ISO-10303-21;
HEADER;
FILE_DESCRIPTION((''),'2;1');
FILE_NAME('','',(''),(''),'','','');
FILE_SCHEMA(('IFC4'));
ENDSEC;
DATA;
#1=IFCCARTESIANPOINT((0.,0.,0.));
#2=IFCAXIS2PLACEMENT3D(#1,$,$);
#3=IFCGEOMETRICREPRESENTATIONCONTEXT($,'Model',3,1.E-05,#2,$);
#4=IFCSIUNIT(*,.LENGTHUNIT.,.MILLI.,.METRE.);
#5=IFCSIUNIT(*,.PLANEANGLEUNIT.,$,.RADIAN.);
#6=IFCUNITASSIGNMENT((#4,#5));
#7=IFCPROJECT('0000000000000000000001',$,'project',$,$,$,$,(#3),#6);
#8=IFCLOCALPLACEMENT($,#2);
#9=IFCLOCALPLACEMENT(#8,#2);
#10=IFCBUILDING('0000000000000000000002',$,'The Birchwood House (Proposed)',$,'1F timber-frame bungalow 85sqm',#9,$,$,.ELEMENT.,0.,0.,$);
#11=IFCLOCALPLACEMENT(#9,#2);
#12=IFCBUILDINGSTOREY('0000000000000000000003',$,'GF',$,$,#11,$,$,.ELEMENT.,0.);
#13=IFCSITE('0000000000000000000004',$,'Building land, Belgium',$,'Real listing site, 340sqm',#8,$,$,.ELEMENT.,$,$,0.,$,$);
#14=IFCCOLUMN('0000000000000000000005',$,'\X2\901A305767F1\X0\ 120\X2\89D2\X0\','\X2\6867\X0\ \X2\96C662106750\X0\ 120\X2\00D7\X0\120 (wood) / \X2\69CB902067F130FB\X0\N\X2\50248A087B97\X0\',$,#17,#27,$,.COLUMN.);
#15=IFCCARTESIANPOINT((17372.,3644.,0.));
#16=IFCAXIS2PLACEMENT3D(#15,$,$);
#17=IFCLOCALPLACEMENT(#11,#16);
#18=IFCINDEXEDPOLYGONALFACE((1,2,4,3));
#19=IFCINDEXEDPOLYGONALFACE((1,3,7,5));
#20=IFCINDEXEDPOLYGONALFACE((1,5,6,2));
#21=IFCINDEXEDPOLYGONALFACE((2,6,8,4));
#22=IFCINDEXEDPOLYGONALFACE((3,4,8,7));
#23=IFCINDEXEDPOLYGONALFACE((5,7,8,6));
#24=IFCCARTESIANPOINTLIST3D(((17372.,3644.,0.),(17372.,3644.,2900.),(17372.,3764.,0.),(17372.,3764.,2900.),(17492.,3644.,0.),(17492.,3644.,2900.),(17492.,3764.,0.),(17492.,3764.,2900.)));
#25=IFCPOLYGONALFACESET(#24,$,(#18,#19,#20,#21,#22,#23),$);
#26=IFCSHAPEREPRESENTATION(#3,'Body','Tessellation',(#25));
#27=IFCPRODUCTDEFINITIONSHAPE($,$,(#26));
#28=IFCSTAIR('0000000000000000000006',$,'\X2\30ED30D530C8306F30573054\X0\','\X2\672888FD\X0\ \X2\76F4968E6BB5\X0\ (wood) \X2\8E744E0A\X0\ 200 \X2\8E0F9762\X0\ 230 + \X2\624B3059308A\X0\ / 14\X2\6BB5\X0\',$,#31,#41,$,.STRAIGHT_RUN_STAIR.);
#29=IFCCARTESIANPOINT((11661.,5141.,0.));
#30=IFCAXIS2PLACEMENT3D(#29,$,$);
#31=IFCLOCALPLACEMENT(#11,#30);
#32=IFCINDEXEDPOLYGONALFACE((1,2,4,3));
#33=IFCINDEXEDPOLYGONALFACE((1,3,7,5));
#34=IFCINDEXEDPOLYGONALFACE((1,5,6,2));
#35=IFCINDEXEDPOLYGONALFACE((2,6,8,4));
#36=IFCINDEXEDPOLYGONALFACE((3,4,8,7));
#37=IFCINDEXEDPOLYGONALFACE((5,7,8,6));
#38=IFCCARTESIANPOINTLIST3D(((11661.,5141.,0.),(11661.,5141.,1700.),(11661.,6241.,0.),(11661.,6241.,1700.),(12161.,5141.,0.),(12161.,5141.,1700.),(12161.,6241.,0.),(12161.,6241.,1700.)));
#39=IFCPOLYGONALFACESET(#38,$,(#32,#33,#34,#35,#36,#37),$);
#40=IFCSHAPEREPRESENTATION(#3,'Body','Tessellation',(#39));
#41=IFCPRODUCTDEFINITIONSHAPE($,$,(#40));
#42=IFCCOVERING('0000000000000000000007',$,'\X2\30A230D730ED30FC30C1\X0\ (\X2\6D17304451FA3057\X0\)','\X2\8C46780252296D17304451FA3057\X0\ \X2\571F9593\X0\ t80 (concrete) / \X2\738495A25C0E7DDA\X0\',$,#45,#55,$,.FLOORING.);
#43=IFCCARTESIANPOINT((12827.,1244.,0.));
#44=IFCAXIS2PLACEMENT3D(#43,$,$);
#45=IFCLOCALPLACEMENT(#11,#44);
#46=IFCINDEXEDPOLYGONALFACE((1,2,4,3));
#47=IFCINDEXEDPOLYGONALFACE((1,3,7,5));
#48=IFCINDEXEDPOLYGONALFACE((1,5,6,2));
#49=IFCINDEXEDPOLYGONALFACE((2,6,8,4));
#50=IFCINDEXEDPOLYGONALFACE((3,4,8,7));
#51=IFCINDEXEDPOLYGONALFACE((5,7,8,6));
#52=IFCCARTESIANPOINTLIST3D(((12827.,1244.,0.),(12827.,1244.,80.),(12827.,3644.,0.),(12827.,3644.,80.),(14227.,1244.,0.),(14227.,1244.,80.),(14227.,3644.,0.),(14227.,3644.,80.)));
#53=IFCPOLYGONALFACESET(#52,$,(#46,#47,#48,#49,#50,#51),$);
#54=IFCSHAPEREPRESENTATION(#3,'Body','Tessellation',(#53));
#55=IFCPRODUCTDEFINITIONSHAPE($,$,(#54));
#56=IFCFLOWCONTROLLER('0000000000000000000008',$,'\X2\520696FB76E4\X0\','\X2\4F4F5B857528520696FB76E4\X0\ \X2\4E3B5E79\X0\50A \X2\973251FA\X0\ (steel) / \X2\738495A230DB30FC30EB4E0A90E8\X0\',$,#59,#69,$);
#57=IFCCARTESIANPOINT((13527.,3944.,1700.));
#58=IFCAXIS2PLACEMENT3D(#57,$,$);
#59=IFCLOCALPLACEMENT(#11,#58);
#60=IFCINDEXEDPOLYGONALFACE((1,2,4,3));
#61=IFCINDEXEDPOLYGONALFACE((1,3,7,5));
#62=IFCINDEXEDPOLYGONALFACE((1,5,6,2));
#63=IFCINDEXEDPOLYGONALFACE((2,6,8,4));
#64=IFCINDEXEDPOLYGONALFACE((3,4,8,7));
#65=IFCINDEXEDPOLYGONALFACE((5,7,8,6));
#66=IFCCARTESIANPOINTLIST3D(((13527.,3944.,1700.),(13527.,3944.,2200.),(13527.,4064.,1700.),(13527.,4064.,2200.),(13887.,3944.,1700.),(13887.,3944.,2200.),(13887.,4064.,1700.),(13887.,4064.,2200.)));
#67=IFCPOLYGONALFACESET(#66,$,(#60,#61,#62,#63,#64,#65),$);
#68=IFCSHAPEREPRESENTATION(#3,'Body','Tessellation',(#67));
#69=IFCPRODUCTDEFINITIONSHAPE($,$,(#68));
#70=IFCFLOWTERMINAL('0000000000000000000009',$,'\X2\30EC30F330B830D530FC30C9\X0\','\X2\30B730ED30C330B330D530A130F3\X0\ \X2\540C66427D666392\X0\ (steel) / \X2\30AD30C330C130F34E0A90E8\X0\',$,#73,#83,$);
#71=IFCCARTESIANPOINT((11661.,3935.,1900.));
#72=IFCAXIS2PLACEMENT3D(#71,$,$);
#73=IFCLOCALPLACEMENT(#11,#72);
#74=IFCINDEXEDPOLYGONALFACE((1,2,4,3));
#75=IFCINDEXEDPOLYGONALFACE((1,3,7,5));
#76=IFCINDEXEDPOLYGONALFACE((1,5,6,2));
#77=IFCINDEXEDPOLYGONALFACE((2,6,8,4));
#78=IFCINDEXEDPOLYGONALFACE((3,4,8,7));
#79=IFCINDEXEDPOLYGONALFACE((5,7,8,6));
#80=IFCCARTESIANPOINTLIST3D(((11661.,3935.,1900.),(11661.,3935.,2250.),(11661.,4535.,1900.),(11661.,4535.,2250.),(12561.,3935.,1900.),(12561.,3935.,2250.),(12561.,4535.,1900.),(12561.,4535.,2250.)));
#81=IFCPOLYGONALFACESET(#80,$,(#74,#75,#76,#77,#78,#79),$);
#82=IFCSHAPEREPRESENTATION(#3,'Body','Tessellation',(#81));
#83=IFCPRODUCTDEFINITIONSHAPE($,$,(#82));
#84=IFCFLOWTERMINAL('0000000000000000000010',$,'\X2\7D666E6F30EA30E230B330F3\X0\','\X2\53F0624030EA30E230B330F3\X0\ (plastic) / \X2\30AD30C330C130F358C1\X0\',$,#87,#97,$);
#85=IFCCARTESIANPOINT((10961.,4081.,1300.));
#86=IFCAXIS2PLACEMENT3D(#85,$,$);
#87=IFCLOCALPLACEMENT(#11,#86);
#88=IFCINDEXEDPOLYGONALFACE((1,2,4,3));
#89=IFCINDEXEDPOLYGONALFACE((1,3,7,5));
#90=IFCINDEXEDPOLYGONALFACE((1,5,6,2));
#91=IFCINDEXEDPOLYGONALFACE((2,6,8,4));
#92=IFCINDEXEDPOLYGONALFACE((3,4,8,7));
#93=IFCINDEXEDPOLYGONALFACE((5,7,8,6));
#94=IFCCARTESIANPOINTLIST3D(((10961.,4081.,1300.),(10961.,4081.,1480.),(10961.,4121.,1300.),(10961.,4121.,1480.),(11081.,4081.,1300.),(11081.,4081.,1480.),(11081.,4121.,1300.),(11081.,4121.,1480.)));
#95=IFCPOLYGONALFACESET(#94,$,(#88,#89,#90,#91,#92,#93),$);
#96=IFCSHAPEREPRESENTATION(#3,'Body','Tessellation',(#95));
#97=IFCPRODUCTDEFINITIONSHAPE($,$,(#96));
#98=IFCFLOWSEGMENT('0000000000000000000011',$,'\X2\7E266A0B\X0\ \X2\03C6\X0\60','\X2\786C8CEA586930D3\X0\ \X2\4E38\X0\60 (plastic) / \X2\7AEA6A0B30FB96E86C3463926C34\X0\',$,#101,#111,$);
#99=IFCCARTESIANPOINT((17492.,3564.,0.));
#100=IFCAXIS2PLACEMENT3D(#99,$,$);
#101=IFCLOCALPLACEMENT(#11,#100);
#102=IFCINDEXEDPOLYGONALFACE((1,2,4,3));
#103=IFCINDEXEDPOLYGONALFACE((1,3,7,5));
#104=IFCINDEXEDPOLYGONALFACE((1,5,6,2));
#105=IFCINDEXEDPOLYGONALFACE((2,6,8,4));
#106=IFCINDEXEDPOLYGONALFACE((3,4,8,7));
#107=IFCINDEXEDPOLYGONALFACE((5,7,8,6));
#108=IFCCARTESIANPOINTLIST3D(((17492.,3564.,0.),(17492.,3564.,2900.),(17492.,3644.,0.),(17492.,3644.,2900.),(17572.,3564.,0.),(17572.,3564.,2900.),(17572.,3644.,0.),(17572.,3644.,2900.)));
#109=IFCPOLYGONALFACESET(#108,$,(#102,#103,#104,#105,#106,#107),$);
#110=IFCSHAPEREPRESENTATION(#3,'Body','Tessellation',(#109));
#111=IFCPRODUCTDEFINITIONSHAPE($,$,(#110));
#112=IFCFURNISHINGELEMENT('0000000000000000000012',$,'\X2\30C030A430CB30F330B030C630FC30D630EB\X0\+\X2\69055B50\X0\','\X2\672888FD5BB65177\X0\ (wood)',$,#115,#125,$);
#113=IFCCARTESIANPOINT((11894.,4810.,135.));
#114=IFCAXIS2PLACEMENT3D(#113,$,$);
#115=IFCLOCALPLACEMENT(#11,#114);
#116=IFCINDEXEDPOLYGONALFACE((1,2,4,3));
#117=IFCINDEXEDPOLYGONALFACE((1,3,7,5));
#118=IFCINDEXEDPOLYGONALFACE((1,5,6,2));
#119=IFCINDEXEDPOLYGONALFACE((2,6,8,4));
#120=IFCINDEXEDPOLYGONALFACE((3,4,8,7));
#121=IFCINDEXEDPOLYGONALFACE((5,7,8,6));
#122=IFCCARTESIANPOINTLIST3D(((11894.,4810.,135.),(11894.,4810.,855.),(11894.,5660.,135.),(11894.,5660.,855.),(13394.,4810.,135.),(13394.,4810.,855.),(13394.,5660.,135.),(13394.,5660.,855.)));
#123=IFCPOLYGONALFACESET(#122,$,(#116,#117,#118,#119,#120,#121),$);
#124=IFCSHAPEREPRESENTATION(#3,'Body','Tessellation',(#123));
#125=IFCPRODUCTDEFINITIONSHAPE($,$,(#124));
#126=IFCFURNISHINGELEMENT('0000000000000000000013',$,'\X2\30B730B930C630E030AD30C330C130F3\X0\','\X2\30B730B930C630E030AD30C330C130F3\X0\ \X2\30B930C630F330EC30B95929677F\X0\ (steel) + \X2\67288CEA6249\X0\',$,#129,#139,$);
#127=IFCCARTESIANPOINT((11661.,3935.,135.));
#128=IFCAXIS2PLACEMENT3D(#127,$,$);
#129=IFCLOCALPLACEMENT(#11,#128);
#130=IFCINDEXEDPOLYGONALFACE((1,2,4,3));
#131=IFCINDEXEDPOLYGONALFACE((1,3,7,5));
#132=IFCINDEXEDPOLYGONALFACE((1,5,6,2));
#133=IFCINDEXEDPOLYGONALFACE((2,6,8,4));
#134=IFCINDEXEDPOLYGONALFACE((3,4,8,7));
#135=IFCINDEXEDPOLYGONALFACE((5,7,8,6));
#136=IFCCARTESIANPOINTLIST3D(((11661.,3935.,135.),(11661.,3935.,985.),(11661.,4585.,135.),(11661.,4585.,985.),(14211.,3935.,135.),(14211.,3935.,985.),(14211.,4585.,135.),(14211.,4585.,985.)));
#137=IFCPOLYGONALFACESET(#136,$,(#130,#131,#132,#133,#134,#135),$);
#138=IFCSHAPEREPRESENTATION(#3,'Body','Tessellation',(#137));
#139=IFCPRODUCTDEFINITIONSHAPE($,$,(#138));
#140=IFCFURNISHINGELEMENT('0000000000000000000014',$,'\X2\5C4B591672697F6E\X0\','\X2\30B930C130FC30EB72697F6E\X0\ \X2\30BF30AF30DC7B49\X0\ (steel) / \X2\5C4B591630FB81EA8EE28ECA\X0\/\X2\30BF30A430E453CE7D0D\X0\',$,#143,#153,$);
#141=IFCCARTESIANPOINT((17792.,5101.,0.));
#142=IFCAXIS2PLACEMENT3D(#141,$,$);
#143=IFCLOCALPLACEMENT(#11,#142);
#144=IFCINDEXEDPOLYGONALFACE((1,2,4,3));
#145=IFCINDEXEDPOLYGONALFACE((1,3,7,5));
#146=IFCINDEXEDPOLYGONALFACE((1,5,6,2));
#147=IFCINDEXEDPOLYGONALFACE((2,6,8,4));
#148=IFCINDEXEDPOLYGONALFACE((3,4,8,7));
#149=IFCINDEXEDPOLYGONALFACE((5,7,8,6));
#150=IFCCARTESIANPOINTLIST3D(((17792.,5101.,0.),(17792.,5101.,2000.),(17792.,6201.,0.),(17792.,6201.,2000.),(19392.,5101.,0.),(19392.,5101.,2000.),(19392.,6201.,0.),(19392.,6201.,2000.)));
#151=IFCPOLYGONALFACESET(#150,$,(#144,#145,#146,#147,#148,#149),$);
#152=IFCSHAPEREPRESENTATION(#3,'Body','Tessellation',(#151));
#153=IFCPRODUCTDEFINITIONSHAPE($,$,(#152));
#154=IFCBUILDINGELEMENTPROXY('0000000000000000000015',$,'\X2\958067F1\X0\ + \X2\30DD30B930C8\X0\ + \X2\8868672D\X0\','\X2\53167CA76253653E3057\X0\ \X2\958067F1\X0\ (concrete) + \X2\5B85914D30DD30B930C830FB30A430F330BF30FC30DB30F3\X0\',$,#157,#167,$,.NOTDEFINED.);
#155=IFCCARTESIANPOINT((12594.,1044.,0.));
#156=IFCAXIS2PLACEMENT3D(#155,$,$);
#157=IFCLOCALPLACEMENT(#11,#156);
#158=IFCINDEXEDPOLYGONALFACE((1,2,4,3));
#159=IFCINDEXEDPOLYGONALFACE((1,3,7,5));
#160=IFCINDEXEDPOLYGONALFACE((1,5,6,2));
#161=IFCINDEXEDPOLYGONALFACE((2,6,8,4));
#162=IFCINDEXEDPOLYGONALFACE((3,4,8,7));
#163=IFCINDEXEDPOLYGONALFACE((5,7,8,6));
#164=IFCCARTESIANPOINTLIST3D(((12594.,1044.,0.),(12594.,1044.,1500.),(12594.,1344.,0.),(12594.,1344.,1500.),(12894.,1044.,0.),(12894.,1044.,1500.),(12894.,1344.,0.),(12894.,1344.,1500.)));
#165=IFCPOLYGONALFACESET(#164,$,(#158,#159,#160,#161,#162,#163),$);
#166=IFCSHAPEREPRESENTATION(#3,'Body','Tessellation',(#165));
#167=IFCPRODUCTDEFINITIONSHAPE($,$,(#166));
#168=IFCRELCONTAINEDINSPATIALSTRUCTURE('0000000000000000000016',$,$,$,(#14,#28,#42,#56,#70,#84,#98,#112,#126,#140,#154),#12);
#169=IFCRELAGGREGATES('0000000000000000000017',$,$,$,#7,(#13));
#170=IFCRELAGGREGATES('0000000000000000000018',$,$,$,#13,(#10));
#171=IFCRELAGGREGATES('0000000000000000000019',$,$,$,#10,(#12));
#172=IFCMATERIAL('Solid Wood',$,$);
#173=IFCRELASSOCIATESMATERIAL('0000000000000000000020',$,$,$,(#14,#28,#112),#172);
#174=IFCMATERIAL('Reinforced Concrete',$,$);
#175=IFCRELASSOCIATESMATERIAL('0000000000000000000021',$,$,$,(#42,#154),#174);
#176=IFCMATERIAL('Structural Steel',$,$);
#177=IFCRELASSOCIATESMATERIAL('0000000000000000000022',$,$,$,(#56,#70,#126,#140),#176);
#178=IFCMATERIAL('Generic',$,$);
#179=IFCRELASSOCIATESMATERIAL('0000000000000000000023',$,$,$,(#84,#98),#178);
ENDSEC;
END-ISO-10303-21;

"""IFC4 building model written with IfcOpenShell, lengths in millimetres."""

from ifc_helpers import new_model, si_unit, frame, frame_2d, origin, place, context, project, spatial, rectangle, extrude, material, element, save


model = new_model("IFC4")

# Units and contexts
model_context = context("Model", 3, precision=1e-05, world=origin())
ifc_project = project(units=[si_unit("LENGTHUNIT", "METRE", prefix="MILLI"), si_unit("PLANEANGLEUNIT", "RADIAN")], contexts=[model_context])

# Site, building, storey
site_placement = place(None, origin())
site = spatial("IfcSite", under=ifc_project, at=site_placement, Name="Building land, Belgium", ObjectType="Real listing site, 340sqm", CompositionType="ELEMENT", RefElevation=0.0)
building_placement = place(site_placement, origin())
building = spatial("IfcBuilding", under=site, at=building_placement, Name="The Birchwood House (Proposed)", ObjectType="1F timber-frame bungalow 85sqm", CompositionType="ELEMENT", ElevationOfRefHeight=0.0, ElevationOfTerrain=0.0)
storey_placement = place(building_placement, origin())
storey = spatial("IfcBuildingStorey", under=building, at=storey_placement, Name="GF", CompositionType="ELEMENT", Elevation=0.0)

# Column
ifc_material_1 = material(Name="Solid Wood")
column_1_placement = place(storey_placement, frame((17372.0, 3644.0, 0.0)))
element("IfcColumn", 1, at=column_1_placement, inside=storey, material=ifc_material_1, Name="通し柱 120角", Description="桧 集成材 120×120 (wood) / 構造柱・N値計算", PredefinedType="COLUMN", context=model_context, shape_type="SweptSolid", body=[
    extrude(rectangle(XDim=120.0, YDim=120.0, at=frame_2d((60.0, 60.0))), frame((17372.0, 3644.0, 0.0)), (0.0, 0.0, 1.0), 2900.0),
])

# Stair
stair_placement = place(storey_placement, frame((11661.0, 5141.0, 0.0)))
element("IfcStair", 2, at=stair_placement, inside=storey, material=ifc_material_1, Name="ロフトはしご", Description="木製 直階段 (wood) 蹴上 200 踏面 230 + 手すり / 14段", PredefinedType="STRAIGHT_RUN_STAIR", context=model_context, shape_type="SweptSolid", body=[
    extrude(rectangle(XDim=500.0, YDim=1100.0, at=frame_2d((250.0, 550.0))), frame((11661.0, 5141.0, 0.0)), (0.0, 0.0, 1.0), 1700.0),
])

# Covering
ifc_material_2 = material(Name="Reinforced Concrete")
covering_placement = place(storey_placement, frame((12827.0, 1244.0, 0.0)))
element("IfcCovering", 3, at=covering_placement, inside=storey, material=ifc_material_2, Name="アプローチ (洗い出し)", Description="豆砂利洗い出し 土間 t80 (concrete) / 玄関導線", PredefinedType="FLOORING", context=model_context, shape_type="SweptSolid", body=[
    extrude(rectangle(XDim=1400.0, YDim=2400.0, at=frame_2d((700.0, 1200.0))), frame((12827.0, 1244.0, 0.0)), (0.0, 0.0, 1.0), 80.0),
])

# Flow controller
ifc_material_3 = material(Name="Structural Steel")
flow_controller_placement = place(storey_placement, frame((13527.0, 3944.0, 1700.0)))
element("IfcFlowController", 4, at=flow_controller_placement, inside=storey, material=ifc_material_3, Name="分電盤", Description="住宅用分電盤 主幹50A 露出 (steel) / 玄関ホール上部", context=model_context, shape_type="SweptSolid", body=[
    extrude(rectangle(XDim=360.0, YDim=120.0, at=frame_2d((180.0, 60.0))), frame((13527.0, 3944.0, 1700.0)), (0.0, 0.0, 1.0), 500.0),
])

# Flow terminals
flow_terminal_1_placement = place(storey_placement, frame((11661.0, 3935.0, 1900.0)))
element("IfcFlowTerminal", 5, at=flow_terminal_1_placement, inside=storey, material=ifc_material_3, Name="レンジフード", Description="シロッコファン 同時給排 (steel) / キッチン上部", context=model_context, shape_type="SweptSolid", body=[
    extrude(rectangle(XDim=900.0, YDim=600.0, at=frame_2d((450.0, 300.0))), frame((11661.0, 3935.0, 1900.0)), (0.0, 0.0, 1.0), 350.0),
])
ifc_material_4 = material(Name="Generic")
flow_terminal_2_placement = place(storey_placement, frame((10961.0, 4081.0, 1300.0)))
element("IfcFlowTerminal", 6, at=flow_terminal_2_placement, inside=storey, material=ifc_material_4, Name="給湯リモコン", Description="台所リモコン (plastic) / キッチン壁", context=model_context, shape_type="SweptSolid", body=[
    extrude(rectangle(XDim=120.0, YDim=40.0, at=frame_2d((60.0, 20.0))), frame((10961.0, 4081.0, 1300.0)), (0.0, 0.0, 1.0), 180.0),
])

# Flow segment
flow_segment_placement = place(storey_placement, frame((17492.0, 3564.0, 0.0)))
element("IfcFlowSegment", 7, at=flow_segment_placement, inside=storey, material=ifc_material_4, Name="縦樋 φ60", Description="硬質塩ビ 丸60 (plastic) / 竪樋・雨水排水", context=model_context, shape_type="SweptSolid", body=[
    extrude(rectangle(XDim=80.0, YDim=80.0, at=frame_2d((40.0, 40.0))), frame((17492.0, 3564.0, 0.0)), (0.0, 0.0, 1.0), 2900.0),
])

# Furnishing elements
furnishing_1_placement = place(storey_placement, frame((11894.0, 4810.0, 135.0)))
element("IfcFurnishingElement", 8, at=furnishing_1_placement, inside=storey, material=ifc_material_1, Name="ダイニングテーブル+椅子", Description="木製家具 (wood)", context=model_context, shape_type="SweptSolid", body=[
    extrude(rectangle(XDim=1500.0, YDim=850.0, at=frame_2d((750.0, 425.0))), frame((11894.0, 4810.0, 135.0)), (0.0, 0.0, 1.0), 720.0),
])
furnishing_2_placement = place(storey_placement, frame((11661.0, 3935.0, 135.0)))
element("IfcFurnishingElement", 9, at=furnishing_2_placement, inside=storey, material=ifc_material_3, Name="システムキッチン", Description="システムキッチン ステンレス天板 (steel) + 木質扉", context=model_context, shape_type="SweptSolid", body=[
    extrude(rectangle(XDim=2550.0, YDim=650.0, at=frame_2d((1275.0, 325.0))), frame((11661.0, 3935.0, 135.0)), (0.0, 0.0, 1.0), 850.0),
])
furnishing_3_placement = place(storey_placement, frame((17792.0, 5101.0, 0.0)))
element("IfcFurnishingElement", 10, at=furnishing_3_placement, inside=storey, material=ifc_material_3, Name="屋外物置", Description="スチール物置 タクボ等 (steel) / 屋外・自転車/タイヤ収納", context=model_context, shape_type="SweptSolid", body=[
    extrude(rectangle(XDim=1600.0, YDim=1100.0, at=frame_2d((800.0, 550.0))), frame((17792.0, 5101.0, 0.0)), (0.0, 0.0, 1.0), 2000.0),
])

# Building element proxy
proxy_placement = place(storey_placement, frame((12594.0, 1044.0, 0.0)))
element("IfcBuildingElementProxy", 11, at=proxy_placement, inside=storey, material=ifc_material_2, Name="門柱 + ポスト + 表札", Description="化粧打放し 門柱 (concrete) + 宅配ポスト・インターホン", PredefinedType="NOTDEFINED", context=model_context, shape_type="SweptSolid", body=[
    extrude(rectangle(XDim=300.0, YDim=300.0, at=frame_2d((150.0, 150.0))), frame((12594.0, 1044.0, 0.0)), (0.0, 0.0, 1.0), 1500.0),
])

save(model, "model.ifc")
